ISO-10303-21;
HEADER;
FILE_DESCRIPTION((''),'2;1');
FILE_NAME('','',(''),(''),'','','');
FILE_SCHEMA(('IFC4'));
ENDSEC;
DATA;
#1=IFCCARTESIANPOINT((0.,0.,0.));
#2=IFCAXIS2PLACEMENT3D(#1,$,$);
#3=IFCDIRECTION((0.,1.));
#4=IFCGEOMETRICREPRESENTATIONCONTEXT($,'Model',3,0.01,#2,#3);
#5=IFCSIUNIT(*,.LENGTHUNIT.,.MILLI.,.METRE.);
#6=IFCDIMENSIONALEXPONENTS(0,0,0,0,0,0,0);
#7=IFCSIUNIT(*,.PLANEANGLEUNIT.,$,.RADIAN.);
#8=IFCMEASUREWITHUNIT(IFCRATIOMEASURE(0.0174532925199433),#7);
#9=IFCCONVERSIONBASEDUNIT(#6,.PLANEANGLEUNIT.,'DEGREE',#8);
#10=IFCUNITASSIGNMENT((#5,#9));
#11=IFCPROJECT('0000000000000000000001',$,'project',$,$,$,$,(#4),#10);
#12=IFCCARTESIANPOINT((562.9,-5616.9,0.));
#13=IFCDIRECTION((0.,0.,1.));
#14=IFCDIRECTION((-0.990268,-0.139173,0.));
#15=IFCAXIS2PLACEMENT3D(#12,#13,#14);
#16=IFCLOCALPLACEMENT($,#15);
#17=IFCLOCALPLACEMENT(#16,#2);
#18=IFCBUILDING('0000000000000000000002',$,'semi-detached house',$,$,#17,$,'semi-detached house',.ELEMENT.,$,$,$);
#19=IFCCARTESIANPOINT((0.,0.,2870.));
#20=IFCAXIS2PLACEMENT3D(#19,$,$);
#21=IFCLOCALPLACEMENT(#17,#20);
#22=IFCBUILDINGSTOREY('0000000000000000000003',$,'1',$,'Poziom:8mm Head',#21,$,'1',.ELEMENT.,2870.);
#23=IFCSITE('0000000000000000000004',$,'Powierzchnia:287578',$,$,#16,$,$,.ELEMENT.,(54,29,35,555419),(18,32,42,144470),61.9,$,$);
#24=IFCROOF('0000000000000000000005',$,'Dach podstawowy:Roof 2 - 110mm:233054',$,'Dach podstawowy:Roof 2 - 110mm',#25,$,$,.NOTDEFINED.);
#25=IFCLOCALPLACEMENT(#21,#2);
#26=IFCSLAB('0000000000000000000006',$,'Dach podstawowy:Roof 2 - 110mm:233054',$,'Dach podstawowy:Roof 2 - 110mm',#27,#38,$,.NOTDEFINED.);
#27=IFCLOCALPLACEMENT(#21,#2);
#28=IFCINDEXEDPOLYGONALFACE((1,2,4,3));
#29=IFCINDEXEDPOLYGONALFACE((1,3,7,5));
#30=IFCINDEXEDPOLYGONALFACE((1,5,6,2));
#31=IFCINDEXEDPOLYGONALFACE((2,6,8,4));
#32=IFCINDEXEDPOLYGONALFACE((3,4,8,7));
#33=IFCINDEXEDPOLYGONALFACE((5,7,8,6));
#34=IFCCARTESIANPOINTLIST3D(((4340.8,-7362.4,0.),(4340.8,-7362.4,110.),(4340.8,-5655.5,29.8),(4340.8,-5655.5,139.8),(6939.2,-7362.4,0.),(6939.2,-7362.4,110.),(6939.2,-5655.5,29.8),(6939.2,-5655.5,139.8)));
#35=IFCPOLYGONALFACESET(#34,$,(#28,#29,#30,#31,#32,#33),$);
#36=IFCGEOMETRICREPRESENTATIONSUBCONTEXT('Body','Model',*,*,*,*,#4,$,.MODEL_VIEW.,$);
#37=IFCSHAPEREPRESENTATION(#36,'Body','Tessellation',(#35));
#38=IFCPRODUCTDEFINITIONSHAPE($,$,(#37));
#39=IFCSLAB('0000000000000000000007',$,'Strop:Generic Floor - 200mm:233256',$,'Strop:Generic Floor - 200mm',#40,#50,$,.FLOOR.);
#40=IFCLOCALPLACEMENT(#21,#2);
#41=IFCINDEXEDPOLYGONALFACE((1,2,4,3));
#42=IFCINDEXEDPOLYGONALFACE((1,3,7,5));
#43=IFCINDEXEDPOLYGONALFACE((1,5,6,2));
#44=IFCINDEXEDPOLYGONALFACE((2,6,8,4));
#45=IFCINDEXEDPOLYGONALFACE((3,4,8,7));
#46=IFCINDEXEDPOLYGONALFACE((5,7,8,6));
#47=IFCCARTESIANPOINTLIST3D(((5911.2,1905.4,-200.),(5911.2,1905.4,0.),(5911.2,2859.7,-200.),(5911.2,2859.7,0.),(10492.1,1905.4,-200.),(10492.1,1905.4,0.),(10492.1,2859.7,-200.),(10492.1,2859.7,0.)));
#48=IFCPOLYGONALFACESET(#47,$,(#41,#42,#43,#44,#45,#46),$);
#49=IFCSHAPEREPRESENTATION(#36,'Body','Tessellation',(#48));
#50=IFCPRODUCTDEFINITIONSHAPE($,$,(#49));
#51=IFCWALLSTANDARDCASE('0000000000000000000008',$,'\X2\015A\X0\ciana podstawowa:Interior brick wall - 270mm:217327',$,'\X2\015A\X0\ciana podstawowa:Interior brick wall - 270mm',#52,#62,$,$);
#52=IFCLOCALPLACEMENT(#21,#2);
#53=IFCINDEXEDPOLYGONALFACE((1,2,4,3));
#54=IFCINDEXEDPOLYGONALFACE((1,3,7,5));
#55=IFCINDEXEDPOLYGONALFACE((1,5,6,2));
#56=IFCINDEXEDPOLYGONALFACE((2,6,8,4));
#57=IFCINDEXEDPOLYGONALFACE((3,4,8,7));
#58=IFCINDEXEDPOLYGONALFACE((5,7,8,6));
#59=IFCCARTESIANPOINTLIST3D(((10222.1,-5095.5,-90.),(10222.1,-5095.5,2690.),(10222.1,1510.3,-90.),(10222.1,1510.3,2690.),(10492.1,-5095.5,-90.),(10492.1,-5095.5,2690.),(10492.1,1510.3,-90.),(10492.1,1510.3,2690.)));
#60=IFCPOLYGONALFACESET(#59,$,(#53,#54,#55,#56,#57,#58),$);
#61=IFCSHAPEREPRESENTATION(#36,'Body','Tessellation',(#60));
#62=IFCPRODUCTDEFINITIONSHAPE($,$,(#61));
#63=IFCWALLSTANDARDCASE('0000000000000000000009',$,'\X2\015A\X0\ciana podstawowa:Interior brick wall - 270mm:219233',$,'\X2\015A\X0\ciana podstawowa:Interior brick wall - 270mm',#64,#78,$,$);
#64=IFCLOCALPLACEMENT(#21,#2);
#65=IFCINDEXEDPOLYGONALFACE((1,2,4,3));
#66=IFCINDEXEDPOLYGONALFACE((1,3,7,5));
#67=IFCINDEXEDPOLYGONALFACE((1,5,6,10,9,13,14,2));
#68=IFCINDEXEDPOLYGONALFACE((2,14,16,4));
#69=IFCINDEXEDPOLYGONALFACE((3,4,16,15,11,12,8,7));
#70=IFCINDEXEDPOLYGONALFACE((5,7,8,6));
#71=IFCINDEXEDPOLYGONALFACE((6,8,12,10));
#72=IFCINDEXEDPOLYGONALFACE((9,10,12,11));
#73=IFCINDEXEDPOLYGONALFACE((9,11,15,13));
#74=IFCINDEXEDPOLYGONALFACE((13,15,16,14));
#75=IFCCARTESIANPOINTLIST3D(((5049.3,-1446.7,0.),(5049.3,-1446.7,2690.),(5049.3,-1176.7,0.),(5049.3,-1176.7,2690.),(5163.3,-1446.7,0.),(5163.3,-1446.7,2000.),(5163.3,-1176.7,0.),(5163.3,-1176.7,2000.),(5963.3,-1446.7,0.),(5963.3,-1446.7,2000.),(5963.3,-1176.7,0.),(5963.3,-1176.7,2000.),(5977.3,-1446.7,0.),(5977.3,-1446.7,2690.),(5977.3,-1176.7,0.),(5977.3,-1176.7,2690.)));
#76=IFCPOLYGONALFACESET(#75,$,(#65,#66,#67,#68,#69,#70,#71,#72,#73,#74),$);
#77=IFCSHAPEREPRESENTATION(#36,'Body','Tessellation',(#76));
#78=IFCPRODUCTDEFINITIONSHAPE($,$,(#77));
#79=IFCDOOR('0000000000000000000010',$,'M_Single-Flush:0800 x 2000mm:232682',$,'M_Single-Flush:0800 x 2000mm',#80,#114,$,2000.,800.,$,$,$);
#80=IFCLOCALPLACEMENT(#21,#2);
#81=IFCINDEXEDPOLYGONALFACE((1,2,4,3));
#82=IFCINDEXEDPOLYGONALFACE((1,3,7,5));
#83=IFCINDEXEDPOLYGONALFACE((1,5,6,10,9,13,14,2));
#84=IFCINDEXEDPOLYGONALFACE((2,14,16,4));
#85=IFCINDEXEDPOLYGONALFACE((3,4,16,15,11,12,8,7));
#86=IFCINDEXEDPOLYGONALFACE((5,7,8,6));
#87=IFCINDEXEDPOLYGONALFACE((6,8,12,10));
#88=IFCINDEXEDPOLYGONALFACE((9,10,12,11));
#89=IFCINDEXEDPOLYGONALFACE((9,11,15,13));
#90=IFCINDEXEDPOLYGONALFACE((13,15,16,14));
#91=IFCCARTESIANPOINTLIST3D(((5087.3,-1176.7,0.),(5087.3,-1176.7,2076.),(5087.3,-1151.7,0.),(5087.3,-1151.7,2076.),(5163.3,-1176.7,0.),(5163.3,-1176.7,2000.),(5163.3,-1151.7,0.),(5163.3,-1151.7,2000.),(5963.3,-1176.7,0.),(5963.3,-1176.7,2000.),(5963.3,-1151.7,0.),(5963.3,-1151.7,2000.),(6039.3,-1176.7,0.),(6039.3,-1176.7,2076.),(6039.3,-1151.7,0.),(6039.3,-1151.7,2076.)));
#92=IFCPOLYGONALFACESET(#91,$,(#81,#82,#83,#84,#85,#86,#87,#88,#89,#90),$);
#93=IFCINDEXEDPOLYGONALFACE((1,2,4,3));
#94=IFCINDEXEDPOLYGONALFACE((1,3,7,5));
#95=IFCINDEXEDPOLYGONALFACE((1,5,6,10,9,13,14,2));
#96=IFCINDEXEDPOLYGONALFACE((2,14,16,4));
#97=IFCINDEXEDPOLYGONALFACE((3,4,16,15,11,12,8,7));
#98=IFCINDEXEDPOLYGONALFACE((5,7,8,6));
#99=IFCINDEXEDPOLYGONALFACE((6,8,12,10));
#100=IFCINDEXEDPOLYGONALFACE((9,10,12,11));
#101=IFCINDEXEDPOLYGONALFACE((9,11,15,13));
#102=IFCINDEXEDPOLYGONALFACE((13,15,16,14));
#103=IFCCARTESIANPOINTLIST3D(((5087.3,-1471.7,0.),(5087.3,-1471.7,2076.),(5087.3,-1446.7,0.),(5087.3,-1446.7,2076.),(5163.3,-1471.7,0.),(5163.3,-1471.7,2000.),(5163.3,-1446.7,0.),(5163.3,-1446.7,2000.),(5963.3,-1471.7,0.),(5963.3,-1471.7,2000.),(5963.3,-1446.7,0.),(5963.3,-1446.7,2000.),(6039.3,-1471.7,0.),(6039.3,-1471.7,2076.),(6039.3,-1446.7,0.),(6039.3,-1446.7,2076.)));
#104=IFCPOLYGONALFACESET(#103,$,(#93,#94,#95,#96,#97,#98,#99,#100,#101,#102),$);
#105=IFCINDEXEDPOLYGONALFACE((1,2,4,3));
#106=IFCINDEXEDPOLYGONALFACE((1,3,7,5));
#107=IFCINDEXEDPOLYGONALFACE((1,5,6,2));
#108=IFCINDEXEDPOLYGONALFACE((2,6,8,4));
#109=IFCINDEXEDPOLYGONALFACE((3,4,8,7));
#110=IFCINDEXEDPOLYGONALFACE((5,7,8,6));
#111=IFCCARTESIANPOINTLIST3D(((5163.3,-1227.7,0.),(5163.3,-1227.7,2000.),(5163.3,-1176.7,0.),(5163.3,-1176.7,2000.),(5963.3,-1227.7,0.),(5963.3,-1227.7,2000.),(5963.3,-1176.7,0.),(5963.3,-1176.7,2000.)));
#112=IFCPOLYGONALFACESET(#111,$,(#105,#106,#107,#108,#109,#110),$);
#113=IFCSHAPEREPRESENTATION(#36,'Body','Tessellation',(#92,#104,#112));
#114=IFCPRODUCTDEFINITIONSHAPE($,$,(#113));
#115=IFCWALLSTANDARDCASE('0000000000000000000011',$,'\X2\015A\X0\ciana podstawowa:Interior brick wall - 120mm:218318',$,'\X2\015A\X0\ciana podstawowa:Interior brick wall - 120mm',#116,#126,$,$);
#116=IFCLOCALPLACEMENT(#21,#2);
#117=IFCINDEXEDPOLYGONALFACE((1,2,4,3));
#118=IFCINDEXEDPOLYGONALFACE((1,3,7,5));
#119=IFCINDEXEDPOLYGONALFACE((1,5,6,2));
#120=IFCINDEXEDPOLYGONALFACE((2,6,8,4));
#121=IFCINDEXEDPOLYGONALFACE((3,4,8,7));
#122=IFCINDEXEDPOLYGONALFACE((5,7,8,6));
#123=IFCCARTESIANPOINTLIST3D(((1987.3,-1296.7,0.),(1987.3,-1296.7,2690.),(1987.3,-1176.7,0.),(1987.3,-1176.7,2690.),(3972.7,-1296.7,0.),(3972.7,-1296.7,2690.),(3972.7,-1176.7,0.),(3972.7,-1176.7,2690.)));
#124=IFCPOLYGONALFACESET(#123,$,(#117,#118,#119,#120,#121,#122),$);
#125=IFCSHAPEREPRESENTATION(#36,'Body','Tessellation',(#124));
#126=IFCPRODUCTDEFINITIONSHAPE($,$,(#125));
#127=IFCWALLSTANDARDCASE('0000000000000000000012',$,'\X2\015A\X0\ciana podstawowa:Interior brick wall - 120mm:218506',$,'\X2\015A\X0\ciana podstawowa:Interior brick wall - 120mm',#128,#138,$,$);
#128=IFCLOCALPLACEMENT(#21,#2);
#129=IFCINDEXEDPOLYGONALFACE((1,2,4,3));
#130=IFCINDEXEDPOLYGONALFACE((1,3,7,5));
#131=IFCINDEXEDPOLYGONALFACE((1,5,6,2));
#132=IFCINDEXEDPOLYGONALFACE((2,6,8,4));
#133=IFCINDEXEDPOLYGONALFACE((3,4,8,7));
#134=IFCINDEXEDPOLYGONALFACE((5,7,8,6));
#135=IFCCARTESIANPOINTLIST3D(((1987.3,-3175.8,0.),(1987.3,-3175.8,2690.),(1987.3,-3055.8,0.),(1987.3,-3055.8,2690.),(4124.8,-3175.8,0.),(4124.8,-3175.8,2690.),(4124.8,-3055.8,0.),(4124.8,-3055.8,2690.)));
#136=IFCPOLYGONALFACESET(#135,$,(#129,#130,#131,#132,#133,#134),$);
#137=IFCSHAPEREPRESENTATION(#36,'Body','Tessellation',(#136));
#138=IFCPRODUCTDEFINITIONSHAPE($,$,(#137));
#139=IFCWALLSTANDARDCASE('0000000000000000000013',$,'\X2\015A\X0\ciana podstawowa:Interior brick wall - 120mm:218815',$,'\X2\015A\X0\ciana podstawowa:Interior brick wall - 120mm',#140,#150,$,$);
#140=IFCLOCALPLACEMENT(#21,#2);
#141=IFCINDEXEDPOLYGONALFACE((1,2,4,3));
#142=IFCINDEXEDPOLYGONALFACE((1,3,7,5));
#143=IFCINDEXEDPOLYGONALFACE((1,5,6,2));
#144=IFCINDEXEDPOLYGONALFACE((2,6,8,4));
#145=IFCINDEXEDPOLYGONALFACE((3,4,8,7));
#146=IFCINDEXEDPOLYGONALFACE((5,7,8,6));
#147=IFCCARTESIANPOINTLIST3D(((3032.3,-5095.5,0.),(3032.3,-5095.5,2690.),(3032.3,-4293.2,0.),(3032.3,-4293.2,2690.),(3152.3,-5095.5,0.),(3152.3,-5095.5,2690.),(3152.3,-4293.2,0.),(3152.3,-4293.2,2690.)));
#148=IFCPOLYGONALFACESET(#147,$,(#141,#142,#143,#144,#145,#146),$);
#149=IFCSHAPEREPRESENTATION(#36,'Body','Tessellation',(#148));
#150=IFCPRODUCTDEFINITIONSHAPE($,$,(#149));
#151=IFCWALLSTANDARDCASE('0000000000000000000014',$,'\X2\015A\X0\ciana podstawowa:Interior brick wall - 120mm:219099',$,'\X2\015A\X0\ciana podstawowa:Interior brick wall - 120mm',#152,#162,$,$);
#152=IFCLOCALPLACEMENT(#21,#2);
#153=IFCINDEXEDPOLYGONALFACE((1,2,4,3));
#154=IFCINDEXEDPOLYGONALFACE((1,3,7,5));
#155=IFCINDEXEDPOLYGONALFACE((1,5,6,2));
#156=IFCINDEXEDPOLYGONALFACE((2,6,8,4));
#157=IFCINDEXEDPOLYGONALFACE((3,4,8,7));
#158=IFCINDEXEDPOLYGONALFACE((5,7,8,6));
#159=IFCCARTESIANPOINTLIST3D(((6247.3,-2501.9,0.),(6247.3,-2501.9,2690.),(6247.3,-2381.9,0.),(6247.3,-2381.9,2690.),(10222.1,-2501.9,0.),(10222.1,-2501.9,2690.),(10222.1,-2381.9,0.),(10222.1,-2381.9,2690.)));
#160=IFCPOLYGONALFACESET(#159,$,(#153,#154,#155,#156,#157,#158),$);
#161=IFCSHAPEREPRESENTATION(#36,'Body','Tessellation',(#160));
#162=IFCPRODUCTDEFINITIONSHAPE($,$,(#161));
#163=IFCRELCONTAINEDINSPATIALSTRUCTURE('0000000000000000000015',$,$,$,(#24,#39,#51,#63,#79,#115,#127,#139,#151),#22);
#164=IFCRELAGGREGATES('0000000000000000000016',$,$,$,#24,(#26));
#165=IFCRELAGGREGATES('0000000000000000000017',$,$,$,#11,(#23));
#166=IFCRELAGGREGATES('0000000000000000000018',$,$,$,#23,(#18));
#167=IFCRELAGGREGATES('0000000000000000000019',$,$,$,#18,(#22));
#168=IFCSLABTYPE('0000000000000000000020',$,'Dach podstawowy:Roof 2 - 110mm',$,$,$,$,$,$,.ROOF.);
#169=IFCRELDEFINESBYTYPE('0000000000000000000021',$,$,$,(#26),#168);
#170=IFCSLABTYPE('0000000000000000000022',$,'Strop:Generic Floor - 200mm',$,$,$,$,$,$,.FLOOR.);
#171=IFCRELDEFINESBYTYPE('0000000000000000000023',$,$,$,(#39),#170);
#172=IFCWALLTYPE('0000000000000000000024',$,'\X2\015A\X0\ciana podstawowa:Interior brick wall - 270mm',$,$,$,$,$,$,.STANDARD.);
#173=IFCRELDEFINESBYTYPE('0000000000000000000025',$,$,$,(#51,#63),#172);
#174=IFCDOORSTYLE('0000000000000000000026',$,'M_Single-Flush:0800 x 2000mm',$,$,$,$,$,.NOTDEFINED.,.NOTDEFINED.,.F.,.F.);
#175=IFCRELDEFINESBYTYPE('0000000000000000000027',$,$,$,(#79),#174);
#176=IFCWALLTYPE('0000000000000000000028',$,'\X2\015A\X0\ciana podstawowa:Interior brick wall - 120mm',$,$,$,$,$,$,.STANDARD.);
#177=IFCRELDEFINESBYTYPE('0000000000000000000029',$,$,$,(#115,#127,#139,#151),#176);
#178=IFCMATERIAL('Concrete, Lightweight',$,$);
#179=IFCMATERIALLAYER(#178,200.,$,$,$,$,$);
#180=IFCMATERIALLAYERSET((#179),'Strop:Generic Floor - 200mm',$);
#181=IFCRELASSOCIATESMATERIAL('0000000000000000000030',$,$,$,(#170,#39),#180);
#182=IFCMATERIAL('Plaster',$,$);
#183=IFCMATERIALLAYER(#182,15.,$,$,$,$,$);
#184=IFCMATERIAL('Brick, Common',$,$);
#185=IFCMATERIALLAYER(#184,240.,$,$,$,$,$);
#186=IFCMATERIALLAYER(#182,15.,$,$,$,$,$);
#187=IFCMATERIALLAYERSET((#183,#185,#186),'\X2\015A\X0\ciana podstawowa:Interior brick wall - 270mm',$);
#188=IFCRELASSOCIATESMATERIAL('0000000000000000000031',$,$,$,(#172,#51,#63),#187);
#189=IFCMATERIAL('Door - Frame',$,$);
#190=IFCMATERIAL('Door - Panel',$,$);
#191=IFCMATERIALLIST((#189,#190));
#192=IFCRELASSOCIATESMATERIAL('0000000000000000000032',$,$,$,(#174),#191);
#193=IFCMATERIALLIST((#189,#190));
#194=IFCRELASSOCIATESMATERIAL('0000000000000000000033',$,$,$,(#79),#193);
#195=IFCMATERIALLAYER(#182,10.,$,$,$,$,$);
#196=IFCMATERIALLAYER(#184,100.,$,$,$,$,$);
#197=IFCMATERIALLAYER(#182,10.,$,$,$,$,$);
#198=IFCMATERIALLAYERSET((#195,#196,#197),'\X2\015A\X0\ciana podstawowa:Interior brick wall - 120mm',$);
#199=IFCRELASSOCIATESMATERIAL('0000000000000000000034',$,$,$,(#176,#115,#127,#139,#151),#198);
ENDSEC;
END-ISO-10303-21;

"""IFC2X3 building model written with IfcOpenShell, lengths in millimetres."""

from ifc_helpers import new_model, entity, si_unit, converted_unit, direction, frame, frame_2d, origin, origin_2d_with_axis, place, context, subcontext, project, spatial, polyline, rectangle, outline, extrude, clip, bounded_halfspace, source, transform, mapped, material, material_list, layer, layer_set, layer_usage, type_object, type_shapes, element, fill, aggregate, save


model = new_model("IFC2X3")

# Units and contexts
model_context = context("Model", 3, precision=0.01, world=origin(), true_north=direction((0.0, 1.0)))
body_context = subcontext(model_context, "Body", "Model", "MODEL_VIEW")
ifc_project = project(units=[si_unit("LENGTHUNIT", "METRE", prefix="MILLI"), converted_unit("PLANEANGLEUNIT", "DEGREE", entity("IfcRatioMeasure", 0.0174532925199433), si_unit("PLANEANGLEUNIT", "RADIAN"), dimensions=[0, 0, 0, 0, 0, 0, 0])], contexts=[model_context])

# Site, building, storey
site_placement = place(None, frame((562.9, -5616.9, 0.0), z_axis=(0.0, 0.0, 1.0), x_axis=(-0.990268, -0.139173, 0.0)))
site = spatial("IfcSite", under=ifc_project, at=site_placement, Name="Powierzchnia:287578", CompositionType="ELEMENT", RefLatitude=(54, 29, 35, 555419), RefLongitude=(18, 32, 42, 144470), RefElevation=61.9)
building_placement = place(site_placement, origin())
building = spatial("IfcBuilding", under=site, at=building_placement, Name="semi-detached house", LongName="semi-detached house", CompositionType="ELEMENT")
storey_placement = place(building_placement, frame((0.0, 0.0, 2870.0)))
storey = spatial("IfcBuildingStorey", under=building, at=storey_placement, Name="1", ObjectType="Poziom:8mm Head", LongName="1", CompositionType="ELEMENT", Elevation=2870.0)

# Shared definitions
ifc_material_1 = material(Name="Concrete, Lightweight")
ifc_material_2 = material(Name="Brick, Common")
ifc_material_3 = material(Name="Plaster")

# Roof, slab
roof_placement = place(storey_placement, frame((4340.8, -7362.4, 0.0)))
roof = element("IfcRoof", 1, at=roof_placement, inside=storey, Name="Dach podstawowy:Roof 2 - 110mm:233054", ObjectType="Dach podstawowy:Roof 2 - 110mm", ShapeType="NOTDEFINED")
slab_type_1 = type_object("IfcSlabType", Name="Dach podstawowy:Roof 2 - 110mm", PredefinedType="ROOF")
slab_1_placement = place(roof_placement, origin())
slab_1 = element("IfcSlab", 2, at=slab_1_placement, type_object=slab_type_1, Name="Dach podstawowy:Roof 2 - 110mm:233054", ObjectType="Dach podstawowy:Roof 2 - 110mm", PredefinedType="NOTDEFINED", context=body_context, shape_type="SweptSolid", body=[
    extrude(rectangle(XDim=1707.1, YDim=2598.3, at=frame_2d((0.0, 0.0), x_axis=(0.0, -1.0))), frame((1299.2, 853.4, 14.9), z_axis=(0.0, -0.017452, 0.999848), x_axis=(1.0, 0.0, 0.0)), (0.0, 0.017452, 0.999848), 110.0),
])
aggregate(roof, [slab_1])

# Slab
ifc_layer_1 = layer(ifc_material_1, 200.0)
ifc_layer_set_1 = layer_set([ifc_layer_1], Name="Strop:Generic Floor - 200mm")
ifc_layer_usage_1 = layer_usage(ifc_layer_set_1, "AXIS3", "POSITIVE", 0.0)
slab_type_2 = type_object("IfcSlabType", Name="Strop:Generic Floor - 200mm", PredefinedType="FLOOR", material=ifc_layer_set_1)
slab_2_placement = place(storey_placement, origin())
element("IfcSlab", 3, at=slab_2_placement, inside=storey, type_object=slab_type_2, material=ifc_layer_usage_1, Name="Strop:Generic Floor - 200mm:233256", ObjectType="Strop:Generic Floor - 200mm", PredefinedType="FLOOR", context=body_context, shape_type="SweptSolid", body=[
    extrude(rectangle(XDim=954.3, YDim=4580.9, at=origin_2d_with_axis()), frame((8201.7, 2382.5, 0.0), z_axis=(0.0, 0.0, -1.0), x_axis=(0.0, 1.0, 0.0)), (0.0, 0.0, 1.0), 200.0),
])

# Wall
ifc_layer_2 = layer(ifc_material_3, 15.0)
ifc_layer_3 = layer(ifc_material_2, 240.0)
ifc_layer_4 = layer(ifc_material_3, 15.0)
ifc_layer_set_2 = layer_set([ifc_layer_2, ifc_layer_3, ifc_layer_4], Name="Ściana podstawowa:Interior brick wall - 270mm")
ifc_layer_usage_2 = layer_usage(ifc_layer_set_2, "AXIS2", "NEGATIVE", 135.0)
wall_type_1 = type_object("IfcWallType", Name="Ściana podstawowa:Interior brick wall - 270mm", PredefinedType="STANDARD", material=ifc_layer_set_2)
wall_1_placement = place(storey_placement, frame((10357.1, 1510.3, -90.0), z_axis=(0.0, 0.0, 1.0), x_axis=(0.0, -1.0, 0.0)))
element("IfcWallStandardCase", 4, at=wall_1_placement, inside=storey, type_object=wall_type_1, material=ifc_layer_usage_2, Name="Ściana podstawowa:Interior brick wall - 270mm:217327", ObjectType="Ściana podstawowa:Interior brick wall - 270mm", context=body_context, shape_type="SweptSolid", body=[
    extrude(rectangle(XDim=6605.8, YDim=270.0, at=frame_2d((3302.9, 0.0), x_axis=(-1.0, 0.0))), origin(), (0.0, 0.0, 1.0), 2780.0),
])

# Wall, opening, door
ifc_layer_usage_3 = layer_usage(ifc_layer_set_2, "AXIS2", "NEGATIVE", 135.0)
wall_2_placement = place(storey_placement, frame((5049.3, -1311.7, 0.0)))
wall_2 = element("IfcWallStandardCase", 5, at=wall_2_placement, inside=storey, type_object=wall_type_1, material=ifc_layer_usage_3, Name="Ściana podstawowa:Interior brick wall - 270mm:219233", ObjectType="Ściana podstawowa:Interior brick wall - 270mm", context=body_context, shape_type="SweptSolid", body=[
    extrude(rectangle(XDim=928.0, YDim=270.0, at=frame_2d((464.0, 0.0), x_axis=(1.0, 0.0))), origin(), (0.0, 0.0, 1.0), 2690.0),
])
opening_1_placement = place(wall_2_placement, frame((114.0, -135.0, 0.0)))
opening_1 = element("IfcOpeningElement", 6, at=opening_1_placement, cuts=wall_2, ObjectType="Opening", context=body_context, shape_type="SweptSolid", body=[
    extrude(rectangle(XDim=800.0, YDim=2000.0, at=frame_2d((1000.0, 400.0), x_axis=(0.0, 1.0))), frame((0.0, 0.0, 0.0), z_axis=(0.0, 1.0, 0.0), x_axis=(0.0, 0.0, 1.0)), (0.0, 0.0, 1.0), 270.0),
])
ifc_material_4 = material(Name="Door - Frame")
ifc_material_5 = material(Name="Door - Panel")
ifc_material_list_1 = material_list([ifc_material_4, ifc_material_5])
ifc_material_list_2 = material_list([ifc_material_4, ifc_material_5])
door_style_1 = type_object("IfcDoorStyle", Name="M_Single-Flush:0800 x 2000mm", ConstructionType="NOTDEFINED", OperationType="NOTDEFINED", ParameterTakesPrecedence=False, Sizeable=False, material=ifc_material_list_2)
shared_shape_1 = source(origin(), body_context, "Body", "SweptSolid", [
    extrude(outline(polyline([(-476.0, -1057.0), (476.0, -1057.0), (476.0, 1019.0), (400.0, 1019.0), (400.0, -981.0), (-400.0, -981.0), (-400.0, 1019.0), (-476.0, 1019.0), (-476.0, -1057.0)])), frame((400.0, 270.0, 1019.0), z_axis=(0.0, 1.0, 0.0), x_axis=(1.0, 0.0, 0.0)), (0.0, 0.0, 1.0), 25.0),
    extrude(outline(polyline([(-1057.0, -476.0), (1019.0, -476.0), (1019.0, -400.0), (-981.0, -400.0), (-981.0, 400.0), (1019.0, 400.0), (1019.0, 476.0), (-1057.0, 476.0), (-1057.0, -476.0)])), frame((400.0, -25.0, 1019.0), z_axis=(0.0, 1.0, 0.0), x_axis=(0.0, 0.0, -1.0)), (0.0, 0.0, 1.0), 25.0),
    extrude(rectangle(XDim=51.0, YDim=800.0, at=frame_2d((0.0, 0.0), x_axis=(1.0, 0.0))), frame((400.0, 244.5, 0.0), z_axis=(0.0, 0.0, 1.0), x_axis=(0.0, 1.0, 0.0)), (0.0, 0.0, 1.0), 2000.0),
])
type_shapes(door_style_1, [shared_shape_1])
door_1_placement = place(opening_1_placement, origin())
door_1 = element("IfcDoor", 7, at=door_1_placement, inside=storey, type_object=door_style_1, material=ifc_material_list_1, Name="M_Single-Flush:0800 x 2000mm:232682", ObjectType="M_Single-Flush:0800 x 2000mm", OverallHeight=2000.0, OverallWidth=800.0, context=body_context, shape_type="MappedRepresentation", body=[
    mapped(shared_shape_1, transform((0.0, 0.0, 0.0), scale=1.0)),
])
fill(opening_1, door_1)

# Walls
ifc_layer_5 = layer(ifc_material_3, 10.0)
ifc_layer_6 = layer(ifc_material_2, 100.0)
ifc_layer_7 = layer(ifc_material_3, 10.0)
ifc_layer_set_3 = layer_set([ifc_layer_5, ifc_layer_6, ifc_layer_7], Name="Ściana podstawowa:Interior brick wall - 120mm")
ifc_layer_usage_4 = layer_usage(ifc_layer_set_3, "AXIS2", "NEGATIVE", 60.0)
wall_type_2 = type_object("IfcWallType", Name="Ściana podstawowa:Interior brick wall - 120mm", PredefinedType="STANDARD", material=ifc_layer_set_3)
wall_3_placement = place(storey_placement, frame((1987.3, -1236.7, 0.0)))
element("IfcWallStandardCase", 8, at=wall_3_placement, inside=storey, type_object=wall_type_2, material=ifc_layer_usage_4, Name="Ściana podstawowa:Interior brick wall - 120mm:218318", ObjectType="Ściana podstawowa:Interior brick wall - 120mm", context=body_context, shape_type="Clipping", body=[
    clip(extrude(rectangle(XDim=1985.4, YDim=120.0, at=frame_2d((992.7, 0.0), x_axis=(-1.0, 0.0))), origin(), (0.0, 0.0, 1.0), 2690.0), bounded_halfspace(frame((1985.4, -60.0, 0.0), z_axis=(0.0, 0.0, 1.0), x_axis=(-1.0, 0.0, 0.0)), True, frame((1985.4, -60.0, 0.0), z_axis=(0.0, 0.0, 1.0), x_axis=(-1.0, 0.0, 0.0)), polyline([(0.0, 0.0), (0.0, -32.9), (0.0, -120.0), (1985.4, -120.0), (1985.4, 0.0), (120.0, 0.0), (0.0, 0.0)]))),
])
ifc_layer_usage_5 = layer_usage(ifc_layer_set_3, "AXIS2", "NEGATIVE", 60.0)
wall_4_placement = place(storey_placement, frame((1987.3, -3115.8, 0.0)))
element("IfcWallStandardCase", 9, at=wall_4_placement, inside=storey, type_object=wall_type_2, material=ifc_layer_usage_5, Name="Ściana podstawowa:Interior brick wall - 120mm:218506", ObjectType="Ściana podstawowa:Interior brick wall - 120mm", context=body_context, shape_type="Clipping", body=[
    clip(extrude(rectangle(XDim=2137.5, YDim=120.0, at=frame_2d((1068.7, 0.0), x_axis=(-1.0, 0.0))), origin(), (0.0, 0.0, 1.0), 2690.0), bounded_halfspace(frame((2137.5, -60.0, 0.0), z_axis=(0.0, 0.0, 1.0), x_axis=(-1.0, 0.0, 0.0)), True, frame((2137.5, -60.0, 0.0), z_axis=(0.0, 0.0, 1.0), x_axis=(-1.0, 0.0, 0.0)), polyline([(0.0, 0.0), (0.0, -120.0), (152.1, -120.0), (272.1, -120.0), (2137.5, -120.0), (2137.5, 0.0), (120.0, 0.0), (0.0, 0.0)]))),
])
ifc_layer_usage_6 = layer_usage(ifc_layer_set_3, "AXIS2", "POSITIVE", -60.0)
wall_5_placement = place(storey_placement, frame((3092.3, -4293.2, 0.0), z_axis=(0.0, 0.0, 1.0), x_axis=(0.0, -1.0, 0.0)))
element("IfcWallStandardCase", 10, at=wall_5_placement, inside=storey, type_object=wall_type_2, material=ifc_layer_usage_6, Name="Ściana podstawowa:Interior brick wall - 120mm:218815", ObjectType="Ściana podstawowa:Interior brick wall - 120mm", context=body_context, shape_type="Clipping", body=[
    clip(extrude(rectangle(XDim=802.4, YDim=120.0, at=frame_2d((401.2, 0.0), x_axis=(-1.0, 0.0))), origin(), (0.0, 0.0, 1.0), 2690.0), bounded_halfspace(frame((802.4, -60.0, 0.0), z_axis=(0.0, 0.0, 1.0), x_axis=(0.0, -1.0, 0.0)), True, frame((802.4, -60.0, 0.0), z_axis=(0.0, 0.0, 1.0), x_axis=(0.0, -1.0, 0.0)), polyline([(0.0, 0.0), (-120.0, 0.0), (-120.0, -802.4), (0.0, -802.4), (0.0, 0.0)]))),
])
ifc_layer_usage_7 = layer_usage(ifc_layer_set_3, "AXIS2", "NEGATIVE", 60.0)
wall_6_placement = place(storey_placement, frame((6247.3, -2441.9, 0.0)))
element("IfcWallStandardCase", 11, at=wall_6_placement, inside=storey, type_object=wall_type_2, material=ifc_layer_usage_7, Name="Ściana podstawowa:Interior brick wall - 120mm:219099", ObjectType="Ściana podstawowa:Interior brick wall - 120mm", context=body_context, shape_type="Clipping", body=[
    clip(extrude(rectangle(XDim=3974.8, YDim=120.0, at=frame_2d((1987.4, 0.0), x_axis=(-1.0, 0.0))), origin(), (0.0, 0.0, 1.0), 2690.0), bounded_halfspace(frame((3974.8, -60.0, 0.0), z_axis=(0.0, 0.0, 1.0), x_axis=(-1.0, 0.0, 0.0)), True, frame((3974.8, -60.0, 0.0), z_axis=(0.0, 0.0, 1.0), x_axis=(-1.0, 0.0, 0.0)), polyline([(0.0, 0.0), (0.0, -120.0), (3974.8, -120.0), (3974.8, 0.0), (3844.8, 0.0), (0.0, 0.0)]))),
])

save(model, "model.ifc")
